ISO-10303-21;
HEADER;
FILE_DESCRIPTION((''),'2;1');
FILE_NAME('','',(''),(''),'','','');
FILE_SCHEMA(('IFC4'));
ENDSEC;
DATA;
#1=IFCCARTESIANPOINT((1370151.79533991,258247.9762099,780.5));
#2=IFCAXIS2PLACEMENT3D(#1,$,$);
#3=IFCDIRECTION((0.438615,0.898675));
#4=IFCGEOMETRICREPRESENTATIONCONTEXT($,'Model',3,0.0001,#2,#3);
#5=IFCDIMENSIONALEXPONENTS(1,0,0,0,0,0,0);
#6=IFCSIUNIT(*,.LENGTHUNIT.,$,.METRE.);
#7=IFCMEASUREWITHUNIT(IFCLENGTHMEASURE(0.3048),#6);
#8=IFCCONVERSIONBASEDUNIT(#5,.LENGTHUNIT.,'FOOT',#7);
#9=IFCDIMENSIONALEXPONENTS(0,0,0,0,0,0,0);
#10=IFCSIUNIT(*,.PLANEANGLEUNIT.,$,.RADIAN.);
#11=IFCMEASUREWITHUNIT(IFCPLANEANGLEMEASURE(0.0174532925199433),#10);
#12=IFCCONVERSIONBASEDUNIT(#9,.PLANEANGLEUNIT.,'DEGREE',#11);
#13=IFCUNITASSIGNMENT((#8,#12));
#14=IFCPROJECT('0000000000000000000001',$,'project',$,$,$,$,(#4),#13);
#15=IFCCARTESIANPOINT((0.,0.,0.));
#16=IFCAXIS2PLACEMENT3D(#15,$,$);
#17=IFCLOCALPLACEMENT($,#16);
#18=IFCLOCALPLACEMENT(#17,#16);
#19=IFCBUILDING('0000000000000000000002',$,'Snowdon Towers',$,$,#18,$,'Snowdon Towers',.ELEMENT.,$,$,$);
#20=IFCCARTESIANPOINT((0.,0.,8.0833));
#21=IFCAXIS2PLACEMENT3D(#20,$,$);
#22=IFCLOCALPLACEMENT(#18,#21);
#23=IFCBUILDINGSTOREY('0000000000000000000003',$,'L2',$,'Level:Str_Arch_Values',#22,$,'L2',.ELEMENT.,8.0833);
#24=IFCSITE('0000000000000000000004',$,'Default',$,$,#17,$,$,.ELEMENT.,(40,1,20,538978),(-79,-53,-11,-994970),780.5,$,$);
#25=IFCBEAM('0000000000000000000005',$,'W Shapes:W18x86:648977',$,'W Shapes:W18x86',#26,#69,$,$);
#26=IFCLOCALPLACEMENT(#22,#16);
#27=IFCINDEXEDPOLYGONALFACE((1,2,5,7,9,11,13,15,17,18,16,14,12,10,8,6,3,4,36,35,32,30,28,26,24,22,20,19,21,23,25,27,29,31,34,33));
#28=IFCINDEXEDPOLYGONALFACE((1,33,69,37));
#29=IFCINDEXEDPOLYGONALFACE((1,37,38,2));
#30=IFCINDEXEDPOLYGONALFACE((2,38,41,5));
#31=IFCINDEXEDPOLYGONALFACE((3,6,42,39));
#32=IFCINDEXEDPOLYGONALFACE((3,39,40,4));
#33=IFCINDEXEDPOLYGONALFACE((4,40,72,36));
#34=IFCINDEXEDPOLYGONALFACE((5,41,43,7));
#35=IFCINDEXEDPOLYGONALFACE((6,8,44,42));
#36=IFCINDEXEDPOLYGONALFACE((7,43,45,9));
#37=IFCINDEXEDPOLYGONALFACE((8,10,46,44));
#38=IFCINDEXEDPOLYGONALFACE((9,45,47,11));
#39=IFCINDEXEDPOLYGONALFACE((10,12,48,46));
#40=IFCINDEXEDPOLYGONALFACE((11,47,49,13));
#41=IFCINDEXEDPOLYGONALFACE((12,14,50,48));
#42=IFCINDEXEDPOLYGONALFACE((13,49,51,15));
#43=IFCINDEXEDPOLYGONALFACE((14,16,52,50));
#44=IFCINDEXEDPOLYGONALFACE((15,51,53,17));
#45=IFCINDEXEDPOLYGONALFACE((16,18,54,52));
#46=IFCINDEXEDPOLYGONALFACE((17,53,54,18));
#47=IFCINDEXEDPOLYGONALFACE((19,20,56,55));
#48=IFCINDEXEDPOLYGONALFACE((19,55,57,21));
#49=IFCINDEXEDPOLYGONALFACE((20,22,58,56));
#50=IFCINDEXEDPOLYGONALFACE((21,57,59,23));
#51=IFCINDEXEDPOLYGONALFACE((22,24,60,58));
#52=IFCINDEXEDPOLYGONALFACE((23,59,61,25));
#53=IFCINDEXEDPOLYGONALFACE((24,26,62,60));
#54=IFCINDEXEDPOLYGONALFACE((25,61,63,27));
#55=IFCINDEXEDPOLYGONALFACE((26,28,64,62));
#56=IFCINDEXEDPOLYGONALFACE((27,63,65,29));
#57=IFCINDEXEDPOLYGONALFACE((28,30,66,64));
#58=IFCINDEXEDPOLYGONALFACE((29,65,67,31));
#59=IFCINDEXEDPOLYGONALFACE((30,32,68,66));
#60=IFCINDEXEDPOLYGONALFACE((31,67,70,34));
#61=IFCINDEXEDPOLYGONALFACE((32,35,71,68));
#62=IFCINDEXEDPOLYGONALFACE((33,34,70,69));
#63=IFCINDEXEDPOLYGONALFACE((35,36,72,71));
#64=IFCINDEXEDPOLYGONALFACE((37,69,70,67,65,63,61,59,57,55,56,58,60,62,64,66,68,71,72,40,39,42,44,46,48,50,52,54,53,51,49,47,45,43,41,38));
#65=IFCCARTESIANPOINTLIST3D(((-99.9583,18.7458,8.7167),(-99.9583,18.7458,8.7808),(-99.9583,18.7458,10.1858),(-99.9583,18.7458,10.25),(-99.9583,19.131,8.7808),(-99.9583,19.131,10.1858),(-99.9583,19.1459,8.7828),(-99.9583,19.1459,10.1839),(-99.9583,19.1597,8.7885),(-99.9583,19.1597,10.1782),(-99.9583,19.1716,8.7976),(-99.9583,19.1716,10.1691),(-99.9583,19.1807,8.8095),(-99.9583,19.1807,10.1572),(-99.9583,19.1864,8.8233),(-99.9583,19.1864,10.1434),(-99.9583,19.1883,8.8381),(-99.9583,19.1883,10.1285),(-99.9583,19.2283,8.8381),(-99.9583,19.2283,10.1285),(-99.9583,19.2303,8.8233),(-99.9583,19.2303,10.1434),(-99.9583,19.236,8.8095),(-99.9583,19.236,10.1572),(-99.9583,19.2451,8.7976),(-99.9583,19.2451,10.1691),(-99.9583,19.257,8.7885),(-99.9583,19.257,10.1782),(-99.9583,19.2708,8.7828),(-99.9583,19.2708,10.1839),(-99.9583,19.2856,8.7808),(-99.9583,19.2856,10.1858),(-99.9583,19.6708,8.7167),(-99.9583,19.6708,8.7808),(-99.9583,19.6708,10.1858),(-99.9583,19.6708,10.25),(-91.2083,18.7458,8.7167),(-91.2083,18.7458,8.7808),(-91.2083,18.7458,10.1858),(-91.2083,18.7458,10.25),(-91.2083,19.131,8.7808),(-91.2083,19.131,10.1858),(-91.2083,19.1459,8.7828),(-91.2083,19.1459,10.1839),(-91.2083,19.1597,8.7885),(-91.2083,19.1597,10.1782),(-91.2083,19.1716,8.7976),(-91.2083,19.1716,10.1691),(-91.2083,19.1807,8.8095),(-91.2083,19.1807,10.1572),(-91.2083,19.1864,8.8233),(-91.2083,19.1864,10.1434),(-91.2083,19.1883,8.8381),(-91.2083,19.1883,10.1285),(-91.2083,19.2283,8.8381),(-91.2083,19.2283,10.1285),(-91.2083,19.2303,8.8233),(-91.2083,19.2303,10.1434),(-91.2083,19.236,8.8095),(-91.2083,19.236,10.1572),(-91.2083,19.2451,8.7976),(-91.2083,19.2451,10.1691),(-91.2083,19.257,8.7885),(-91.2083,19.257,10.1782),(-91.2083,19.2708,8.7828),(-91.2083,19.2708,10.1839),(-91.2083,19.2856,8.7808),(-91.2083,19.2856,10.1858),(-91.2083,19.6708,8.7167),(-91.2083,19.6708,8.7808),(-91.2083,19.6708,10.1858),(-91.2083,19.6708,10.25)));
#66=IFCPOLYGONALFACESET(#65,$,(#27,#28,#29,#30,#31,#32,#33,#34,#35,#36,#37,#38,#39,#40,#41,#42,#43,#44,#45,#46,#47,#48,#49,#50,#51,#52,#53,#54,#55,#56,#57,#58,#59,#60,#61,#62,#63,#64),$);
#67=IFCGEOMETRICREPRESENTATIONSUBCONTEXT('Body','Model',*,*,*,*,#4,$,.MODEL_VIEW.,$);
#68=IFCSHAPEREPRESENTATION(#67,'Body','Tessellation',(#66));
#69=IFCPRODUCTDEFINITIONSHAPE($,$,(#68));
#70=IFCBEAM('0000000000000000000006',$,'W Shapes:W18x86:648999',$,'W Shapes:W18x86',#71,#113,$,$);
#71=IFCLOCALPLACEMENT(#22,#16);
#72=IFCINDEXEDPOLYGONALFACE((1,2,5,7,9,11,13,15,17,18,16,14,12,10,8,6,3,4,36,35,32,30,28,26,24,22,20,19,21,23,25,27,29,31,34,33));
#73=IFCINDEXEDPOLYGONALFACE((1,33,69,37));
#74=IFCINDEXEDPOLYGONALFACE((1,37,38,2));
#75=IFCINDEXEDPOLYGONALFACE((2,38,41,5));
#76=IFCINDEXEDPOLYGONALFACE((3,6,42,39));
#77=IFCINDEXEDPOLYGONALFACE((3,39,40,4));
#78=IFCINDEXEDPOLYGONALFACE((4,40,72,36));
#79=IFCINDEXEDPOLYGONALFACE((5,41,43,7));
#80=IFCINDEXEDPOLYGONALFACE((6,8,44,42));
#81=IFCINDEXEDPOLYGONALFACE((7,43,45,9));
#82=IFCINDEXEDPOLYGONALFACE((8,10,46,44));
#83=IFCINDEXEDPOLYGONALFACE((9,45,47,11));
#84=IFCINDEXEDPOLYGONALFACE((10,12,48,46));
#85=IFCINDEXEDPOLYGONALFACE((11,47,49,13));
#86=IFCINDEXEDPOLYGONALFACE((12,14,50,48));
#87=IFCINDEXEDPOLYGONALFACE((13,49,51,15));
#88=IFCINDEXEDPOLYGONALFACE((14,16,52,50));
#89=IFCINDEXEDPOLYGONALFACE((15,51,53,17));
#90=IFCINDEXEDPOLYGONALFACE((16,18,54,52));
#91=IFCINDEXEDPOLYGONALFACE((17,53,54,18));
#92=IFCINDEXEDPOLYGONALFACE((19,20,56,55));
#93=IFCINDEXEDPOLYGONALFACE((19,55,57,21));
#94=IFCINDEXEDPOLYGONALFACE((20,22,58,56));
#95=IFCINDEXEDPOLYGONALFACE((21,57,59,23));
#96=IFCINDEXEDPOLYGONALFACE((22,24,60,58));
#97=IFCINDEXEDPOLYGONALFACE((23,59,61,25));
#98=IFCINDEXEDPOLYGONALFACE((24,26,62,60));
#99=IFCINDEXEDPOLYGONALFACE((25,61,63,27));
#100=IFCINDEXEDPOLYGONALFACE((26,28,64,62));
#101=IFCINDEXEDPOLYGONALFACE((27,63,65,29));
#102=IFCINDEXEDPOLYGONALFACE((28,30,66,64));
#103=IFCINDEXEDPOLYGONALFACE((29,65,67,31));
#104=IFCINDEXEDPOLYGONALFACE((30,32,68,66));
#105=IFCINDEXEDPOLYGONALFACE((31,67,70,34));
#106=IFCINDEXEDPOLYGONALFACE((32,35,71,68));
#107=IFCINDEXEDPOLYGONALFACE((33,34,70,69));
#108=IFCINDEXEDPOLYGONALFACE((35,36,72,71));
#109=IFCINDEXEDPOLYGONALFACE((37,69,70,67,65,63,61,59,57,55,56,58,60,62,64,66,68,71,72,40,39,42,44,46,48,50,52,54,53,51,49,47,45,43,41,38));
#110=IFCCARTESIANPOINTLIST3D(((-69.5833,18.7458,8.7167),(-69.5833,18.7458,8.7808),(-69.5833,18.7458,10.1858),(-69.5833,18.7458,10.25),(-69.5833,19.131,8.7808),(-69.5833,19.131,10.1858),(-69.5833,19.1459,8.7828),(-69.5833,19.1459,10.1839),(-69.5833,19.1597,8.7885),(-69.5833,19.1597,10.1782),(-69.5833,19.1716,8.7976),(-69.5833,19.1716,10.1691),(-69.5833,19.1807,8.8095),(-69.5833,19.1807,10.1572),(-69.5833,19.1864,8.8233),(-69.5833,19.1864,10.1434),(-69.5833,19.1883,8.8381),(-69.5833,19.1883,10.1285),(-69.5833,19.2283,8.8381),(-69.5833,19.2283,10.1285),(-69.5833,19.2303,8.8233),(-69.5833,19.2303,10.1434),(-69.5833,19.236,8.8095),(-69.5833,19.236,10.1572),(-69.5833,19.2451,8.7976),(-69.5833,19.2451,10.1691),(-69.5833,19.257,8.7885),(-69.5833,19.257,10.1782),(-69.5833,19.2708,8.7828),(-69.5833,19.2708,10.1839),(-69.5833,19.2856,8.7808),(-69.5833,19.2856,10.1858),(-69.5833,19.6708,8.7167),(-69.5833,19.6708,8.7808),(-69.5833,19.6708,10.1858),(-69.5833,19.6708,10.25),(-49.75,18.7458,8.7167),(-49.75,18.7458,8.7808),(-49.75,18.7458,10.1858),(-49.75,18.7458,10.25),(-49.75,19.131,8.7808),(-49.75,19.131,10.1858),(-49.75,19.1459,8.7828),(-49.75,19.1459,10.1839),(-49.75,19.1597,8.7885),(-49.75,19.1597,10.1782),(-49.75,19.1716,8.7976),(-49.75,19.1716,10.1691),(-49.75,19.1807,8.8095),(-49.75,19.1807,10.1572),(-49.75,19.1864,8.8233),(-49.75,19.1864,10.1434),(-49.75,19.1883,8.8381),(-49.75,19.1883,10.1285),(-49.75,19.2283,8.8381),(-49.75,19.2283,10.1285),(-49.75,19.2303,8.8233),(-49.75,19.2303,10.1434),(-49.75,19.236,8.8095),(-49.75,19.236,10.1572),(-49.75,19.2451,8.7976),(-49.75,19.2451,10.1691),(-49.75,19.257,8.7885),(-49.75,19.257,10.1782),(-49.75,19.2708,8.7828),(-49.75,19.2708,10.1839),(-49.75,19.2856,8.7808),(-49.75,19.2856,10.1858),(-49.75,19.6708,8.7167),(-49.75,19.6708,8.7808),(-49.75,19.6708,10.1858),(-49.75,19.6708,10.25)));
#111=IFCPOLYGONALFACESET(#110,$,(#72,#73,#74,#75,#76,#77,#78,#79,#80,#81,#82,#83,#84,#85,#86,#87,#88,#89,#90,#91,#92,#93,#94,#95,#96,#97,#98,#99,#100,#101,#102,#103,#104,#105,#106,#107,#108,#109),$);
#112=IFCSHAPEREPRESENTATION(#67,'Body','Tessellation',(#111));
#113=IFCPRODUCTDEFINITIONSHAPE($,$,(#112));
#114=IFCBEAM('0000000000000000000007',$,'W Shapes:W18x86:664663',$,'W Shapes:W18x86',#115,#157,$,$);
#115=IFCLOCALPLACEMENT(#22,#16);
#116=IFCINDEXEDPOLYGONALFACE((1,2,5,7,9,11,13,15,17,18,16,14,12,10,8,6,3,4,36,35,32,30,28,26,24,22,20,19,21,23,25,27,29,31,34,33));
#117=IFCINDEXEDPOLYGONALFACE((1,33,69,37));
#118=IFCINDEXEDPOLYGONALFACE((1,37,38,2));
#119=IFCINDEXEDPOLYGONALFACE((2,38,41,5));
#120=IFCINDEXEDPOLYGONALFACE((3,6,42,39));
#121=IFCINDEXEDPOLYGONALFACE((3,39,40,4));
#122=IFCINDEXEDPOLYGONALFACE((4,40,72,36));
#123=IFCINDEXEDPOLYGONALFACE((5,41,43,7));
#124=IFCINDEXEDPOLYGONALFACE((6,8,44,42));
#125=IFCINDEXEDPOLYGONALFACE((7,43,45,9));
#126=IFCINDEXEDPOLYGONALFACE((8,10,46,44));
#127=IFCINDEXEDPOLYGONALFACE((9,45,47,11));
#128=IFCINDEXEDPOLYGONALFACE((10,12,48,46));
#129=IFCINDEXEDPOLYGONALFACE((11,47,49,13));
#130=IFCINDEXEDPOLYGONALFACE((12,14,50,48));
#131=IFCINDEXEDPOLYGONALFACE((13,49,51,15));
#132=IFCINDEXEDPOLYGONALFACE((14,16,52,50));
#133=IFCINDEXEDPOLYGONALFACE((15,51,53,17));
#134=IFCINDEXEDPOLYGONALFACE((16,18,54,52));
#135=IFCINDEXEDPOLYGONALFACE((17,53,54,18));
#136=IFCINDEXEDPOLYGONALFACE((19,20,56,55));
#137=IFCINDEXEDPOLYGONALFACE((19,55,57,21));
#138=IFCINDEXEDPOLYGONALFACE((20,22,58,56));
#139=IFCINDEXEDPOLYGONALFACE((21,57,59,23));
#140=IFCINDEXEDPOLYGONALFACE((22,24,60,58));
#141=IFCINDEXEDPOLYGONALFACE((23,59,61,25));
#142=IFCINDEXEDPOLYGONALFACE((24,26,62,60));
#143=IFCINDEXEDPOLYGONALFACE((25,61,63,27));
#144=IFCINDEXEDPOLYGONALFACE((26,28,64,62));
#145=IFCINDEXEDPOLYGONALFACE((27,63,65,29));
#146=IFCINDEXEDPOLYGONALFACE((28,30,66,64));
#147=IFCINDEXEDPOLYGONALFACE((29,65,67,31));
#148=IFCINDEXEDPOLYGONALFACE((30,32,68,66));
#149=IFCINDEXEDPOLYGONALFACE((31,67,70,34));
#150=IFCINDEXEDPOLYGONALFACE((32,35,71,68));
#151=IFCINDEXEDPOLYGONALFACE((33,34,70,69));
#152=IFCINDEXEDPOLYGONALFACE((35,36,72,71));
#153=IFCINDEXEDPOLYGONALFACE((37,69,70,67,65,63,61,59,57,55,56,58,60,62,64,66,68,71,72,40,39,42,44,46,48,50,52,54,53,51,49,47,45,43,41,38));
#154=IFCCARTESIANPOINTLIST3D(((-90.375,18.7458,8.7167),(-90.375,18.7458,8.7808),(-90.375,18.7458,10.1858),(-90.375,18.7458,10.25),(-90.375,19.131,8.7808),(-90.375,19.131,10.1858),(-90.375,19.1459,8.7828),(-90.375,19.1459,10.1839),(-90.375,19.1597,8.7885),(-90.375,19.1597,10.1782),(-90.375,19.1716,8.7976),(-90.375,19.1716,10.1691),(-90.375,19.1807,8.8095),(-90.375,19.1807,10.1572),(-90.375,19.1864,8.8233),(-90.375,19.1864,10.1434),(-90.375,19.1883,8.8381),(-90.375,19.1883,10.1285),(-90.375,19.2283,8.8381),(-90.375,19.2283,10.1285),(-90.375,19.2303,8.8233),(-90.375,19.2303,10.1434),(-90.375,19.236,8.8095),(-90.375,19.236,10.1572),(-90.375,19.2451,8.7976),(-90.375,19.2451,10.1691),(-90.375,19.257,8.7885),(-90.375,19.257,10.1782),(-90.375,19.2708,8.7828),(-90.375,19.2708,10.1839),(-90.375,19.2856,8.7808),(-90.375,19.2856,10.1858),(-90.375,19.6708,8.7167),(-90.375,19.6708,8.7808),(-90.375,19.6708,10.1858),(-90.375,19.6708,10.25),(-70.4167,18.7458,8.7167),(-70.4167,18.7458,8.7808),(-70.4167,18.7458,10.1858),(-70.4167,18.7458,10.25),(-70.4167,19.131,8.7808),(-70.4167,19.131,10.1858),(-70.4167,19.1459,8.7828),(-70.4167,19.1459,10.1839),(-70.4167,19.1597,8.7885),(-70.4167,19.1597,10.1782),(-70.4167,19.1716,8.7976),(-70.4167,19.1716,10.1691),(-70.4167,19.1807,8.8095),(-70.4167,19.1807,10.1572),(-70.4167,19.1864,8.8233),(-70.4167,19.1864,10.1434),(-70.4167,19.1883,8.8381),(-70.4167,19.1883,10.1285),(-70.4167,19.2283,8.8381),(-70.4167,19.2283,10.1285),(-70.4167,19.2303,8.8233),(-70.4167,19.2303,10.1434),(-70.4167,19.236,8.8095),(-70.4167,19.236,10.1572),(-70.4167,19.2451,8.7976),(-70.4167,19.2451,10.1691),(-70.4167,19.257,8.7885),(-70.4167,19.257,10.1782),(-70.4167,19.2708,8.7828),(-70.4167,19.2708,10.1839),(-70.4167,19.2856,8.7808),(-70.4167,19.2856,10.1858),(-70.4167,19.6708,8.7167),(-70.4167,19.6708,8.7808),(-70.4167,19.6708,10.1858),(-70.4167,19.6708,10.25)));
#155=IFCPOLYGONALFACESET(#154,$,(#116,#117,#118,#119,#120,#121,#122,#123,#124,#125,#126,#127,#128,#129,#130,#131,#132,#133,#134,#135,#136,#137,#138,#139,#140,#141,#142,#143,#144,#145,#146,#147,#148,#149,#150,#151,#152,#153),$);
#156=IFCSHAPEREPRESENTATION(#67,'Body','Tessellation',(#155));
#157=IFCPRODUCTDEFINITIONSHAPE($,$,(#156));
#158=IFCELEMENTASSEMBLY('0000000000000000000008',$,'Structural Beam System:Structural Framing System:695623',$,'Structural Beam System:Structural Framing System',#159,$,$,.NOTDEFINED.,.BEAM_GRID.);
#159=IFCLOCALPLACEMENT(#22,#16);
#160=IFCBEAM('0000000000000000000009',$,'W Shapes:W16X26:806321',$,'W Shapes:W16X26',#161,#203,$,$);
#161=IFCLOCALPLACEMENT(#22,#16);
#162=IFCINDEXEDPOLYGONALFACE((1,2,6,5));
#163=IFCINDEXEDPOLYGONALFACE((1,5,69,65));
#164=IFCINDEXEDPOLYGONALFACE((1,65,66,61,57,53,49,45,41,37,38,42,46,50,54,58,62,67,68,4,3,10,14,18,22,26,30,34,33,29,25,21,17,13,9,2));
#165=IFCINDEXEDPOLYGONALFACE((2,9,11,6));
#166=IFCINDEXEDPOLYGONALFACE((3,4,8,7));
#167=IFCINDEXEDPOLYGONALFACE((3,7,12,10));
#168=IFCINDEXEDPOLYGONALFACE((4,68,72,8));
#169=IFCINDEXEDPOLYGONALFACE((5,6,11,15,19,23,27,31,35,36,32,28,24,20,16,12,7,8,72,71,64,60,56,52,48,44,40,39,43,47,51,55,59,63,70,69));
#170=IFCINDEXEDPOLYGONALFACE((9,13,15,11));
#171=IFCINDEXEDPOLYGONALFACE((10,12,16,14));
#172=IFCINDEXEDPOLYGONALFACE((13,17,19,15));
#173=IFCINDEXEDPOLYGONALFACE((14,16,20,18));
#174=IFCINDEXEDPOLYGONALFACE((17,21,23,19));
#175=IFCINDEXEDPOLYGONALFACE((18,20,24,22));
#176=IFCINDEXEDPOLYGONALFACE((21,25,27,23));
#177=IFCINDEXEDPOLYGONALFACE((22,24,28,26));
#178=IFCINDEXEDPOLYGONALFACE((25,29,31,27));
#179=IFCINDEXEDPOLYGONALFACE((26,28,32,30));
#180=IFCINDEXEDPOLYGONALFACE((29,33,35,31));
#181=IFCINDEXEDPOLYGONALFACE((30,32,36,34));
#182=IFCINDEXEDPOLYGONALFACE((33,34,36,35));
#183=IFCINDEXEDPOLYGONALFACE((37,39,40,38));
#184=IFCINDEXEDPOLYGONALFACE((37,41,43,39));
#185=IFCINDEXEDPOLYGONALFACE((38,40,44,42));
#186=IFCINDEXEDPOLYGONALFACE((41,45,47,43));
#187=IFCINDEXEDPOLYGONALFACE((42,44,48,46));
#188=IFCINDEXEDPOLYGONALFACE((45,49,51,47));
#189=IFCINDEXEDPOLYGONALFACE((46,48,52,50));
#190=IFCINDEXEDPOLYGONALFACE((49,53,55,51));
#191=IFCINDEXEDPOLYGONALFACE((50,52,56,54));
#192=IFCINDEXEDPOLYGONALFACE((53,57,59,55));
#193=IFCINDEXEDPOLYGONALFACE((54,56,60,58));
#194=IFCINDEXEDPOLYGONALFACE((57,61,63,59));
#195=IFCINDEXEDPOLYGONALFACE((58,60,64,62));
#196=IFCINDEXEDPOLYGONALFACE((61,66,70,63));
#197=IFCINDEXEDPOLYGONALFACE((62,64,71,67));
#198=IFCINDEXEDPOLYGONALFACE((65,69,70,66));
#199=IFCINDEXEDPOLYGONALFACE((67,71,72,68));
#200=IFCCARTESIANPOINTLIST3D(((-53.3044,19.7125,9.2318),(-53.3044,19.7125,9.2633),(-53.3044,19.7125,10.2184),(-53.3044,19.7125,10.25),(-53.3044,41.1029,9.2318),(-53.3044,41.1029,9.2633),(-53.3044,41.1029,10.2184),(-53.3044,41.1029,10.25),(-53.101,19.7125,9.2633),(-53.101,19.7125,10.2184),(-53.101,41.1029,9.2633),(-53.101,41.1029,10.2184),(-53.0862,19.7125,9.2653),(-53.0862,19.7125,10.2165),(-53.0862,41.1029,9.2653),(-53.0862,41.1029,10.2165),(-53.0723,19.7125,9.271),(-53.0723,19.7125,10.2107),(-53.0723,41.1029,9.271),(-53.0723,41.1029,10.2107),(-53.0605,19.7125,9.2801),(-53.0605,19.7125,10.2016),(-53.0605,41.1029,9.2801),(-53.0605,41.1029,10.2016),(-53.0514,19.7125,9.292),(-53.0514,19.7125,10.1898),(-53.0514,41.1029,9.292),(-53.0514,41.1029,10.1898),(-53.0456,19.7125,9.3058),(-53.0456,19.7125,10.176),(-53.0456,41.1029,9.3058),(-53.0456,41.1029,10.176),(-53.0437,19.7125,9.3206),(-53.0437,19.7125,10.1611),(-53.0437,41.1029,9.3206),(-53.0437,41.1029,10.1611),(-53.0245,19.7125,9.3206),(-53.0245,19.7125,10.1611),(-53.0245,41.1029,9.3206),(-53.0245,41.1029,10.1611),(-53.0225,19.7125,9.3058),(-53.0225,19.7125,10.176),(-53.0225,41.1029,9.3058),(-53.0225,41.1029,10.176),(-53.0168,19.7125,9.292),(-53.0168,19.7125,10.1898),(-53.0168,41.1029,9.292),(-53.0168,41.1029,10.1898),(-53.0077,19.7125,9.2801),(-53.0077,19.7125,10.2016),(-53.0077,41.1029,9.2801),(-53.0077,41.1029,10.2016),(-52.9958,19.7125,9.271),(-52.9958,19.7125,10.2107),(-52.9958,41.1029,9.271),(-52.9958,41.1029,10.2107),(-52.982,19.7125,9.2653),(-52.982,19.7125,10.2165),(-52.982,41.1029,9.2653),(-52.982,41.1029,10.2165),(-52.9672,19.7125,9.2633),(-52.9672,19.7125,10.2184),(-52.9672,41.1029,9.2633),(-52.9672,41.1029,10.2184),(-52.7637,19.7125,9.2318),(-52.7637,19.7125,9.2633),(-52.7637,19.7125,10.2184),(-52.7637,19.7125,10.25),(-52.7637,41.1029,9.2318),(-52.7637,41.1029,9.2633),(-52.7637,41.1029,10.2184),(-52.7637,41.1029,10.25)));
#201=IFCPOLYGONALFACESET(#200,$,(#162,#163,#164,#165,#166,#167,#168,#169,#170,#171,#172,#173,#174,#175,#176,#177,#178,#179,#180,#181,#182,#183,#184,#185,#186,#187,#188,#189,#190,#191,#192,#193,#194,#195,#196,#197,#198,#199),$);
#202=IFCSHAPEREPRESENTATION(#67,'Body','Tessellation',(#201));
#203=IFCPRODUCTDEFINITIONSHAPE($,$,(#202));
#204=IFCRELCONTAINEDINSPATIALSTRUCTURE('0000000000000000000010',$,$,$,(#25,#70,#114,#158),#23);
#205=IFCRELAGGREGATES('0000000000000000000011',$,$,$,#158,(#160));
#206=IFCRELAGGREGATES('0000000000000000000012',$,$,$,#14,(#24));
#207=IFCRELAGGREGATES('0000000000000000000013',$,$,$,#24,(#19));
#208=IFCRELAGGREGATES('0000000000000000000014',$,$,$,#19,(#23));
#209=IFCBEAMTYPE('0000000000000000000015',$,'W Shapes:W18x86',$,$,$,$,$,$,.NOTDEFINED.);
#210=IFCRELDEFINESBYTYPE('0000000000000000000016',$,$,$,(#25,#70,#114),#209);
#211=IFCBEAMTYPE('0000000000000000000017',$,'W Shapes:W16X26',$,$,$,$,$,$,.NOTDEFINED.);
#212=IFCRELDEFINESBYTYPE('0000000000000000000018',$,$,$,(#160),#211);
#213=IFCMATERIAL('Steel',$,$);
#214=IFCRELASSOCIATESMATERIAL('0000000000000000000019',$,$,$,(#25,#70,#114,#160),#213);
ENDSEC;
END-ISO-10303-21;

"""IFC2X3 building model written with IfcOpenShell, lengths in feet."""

from ifc_helpers import new_model, entity, si_unit, converted_unit, direction, frame, frame_2d, origin, place, context, subcontext, project, spatial, i_section, extrude, material, type_object, element, aggregate, save


model = new_model("IFC2X3")

# Units and contexts
model_context = context("Model", 3, precision=0.0001, world=frame((1370151.79533991, 258247.9762099, 780.5)), true_north=direction((0.438615, 0.898675)))
body_context = subcontext(model_context, "Body", "Model", "MODEL_VIEW")
ifc_project = project(units=[converted_unit("LENGTHUNIT", "FOOT", entity("IfcLengthMeasure", 0.3048), si_unit("LENGTHUNIT", "METRE"), dimensions=[1, 0, 0, 0, 0, 0, 0]), converted_unit("PLANEANGLEUNIT", "DEGREE", entity("IfcPlaneAngleMeasure", 0.0174532925199433), si_unit("PLANEANGLEUNIT", "RADIAN"), dimensions=[0, 0, 0, 0, 0, 0, 0])], contexts=[model_context])

# Site, building, storey
site_placement = place(None, origin())
site = spatial("IfcSite", under=ifc_project, at=site_placement, Name="Default", CompositionType="ELEMENT", RefLatitude=(40, 1, 20, 538978), RefLongitude=(-79, -53, -11, -994970), RefElevation=780.5)
building_placement = place(site_placement, origin())
building = spatial("IfcBuilding", under=site, at=building_placement, Name="Snowdon Towers", LongName="Snowdon Towers", CompositionType="ELEMENT")
storey_placement = place(building_placement, frame((0.0, 0.0, 8.0833)))
storey = spatial("IfcBuildingStorey", under=building, at=storey_placement, Name="L2", ObjectType="Level:Str_Arch_Values", LongName="L2", CompositionType="ELEMENT", Elevation=8.0833)

# Shared definitions
ifc_material = material(Name="Steel")

# Beams
beam_type_1 = type_object("IfcBeamType", Name="W Shapes:W18x86", PredefinedType="NOTDEFINED")
beam_1_placement = place(storey_placement, frame((-99.9583, 19.2083, 10.25)))
element("IfcBeam", 1, at=beam_1_placement, inside=storey, type_object=beam_type_1, material=ifc_material, Name="W Shapes:W18x86:648977", ObjectType="W Shapes:W18x86", context=body_context, shape_type="SweptSolid", body=[
    extrude(i_section(OverallWidth=0.925, OverallDepth=1.5333, WebThickness=0.04, FlangeThickness=0.0642, FilletRadius=0.0573, at=frame_2d((0.0, 0.0), x_axis=(0.0, 1.0))), frame((0.0, 0.0, -0.7667), z_axis=(1.0, 0.0, 0.0), x_axis=(0.0, 0.0, -1.0)), (0.0, 0.0, 1.0), 8.75),
])
beam_2_placement = place(storey_placement, frame((-70.0, 19.2083, 10.25)))
element("IfcBeam", 2, at=beam_2_placement, inside=storey, type_object=beam_type_1, material=ifc_material, Name="W Shapes:W18x86:648999", ObjectType="W Shapes:W18x86", context=body_context, shape_type="SweptSolid", body=[
    extrude(i_section(OverallWidth=0.925, OverallDepth=1.5333, WebThickness=0.04, FlangeThickness=0.0642, FilletRadius=0.0573, at=frame_2d((0.0, 0.0), x_axis=(0.0, 1.0))), frame((0.4167, 0.0, -0.7667), z_axis=(1.0, 0.0, 0.0), x_axis=(0.0, 0.0, -1.0)), (0.0, 0.0, 1.0), 19.8333),
])
beam_3_placement = place(storey_placement, frame((-90.75, 19.2083, 10.25)))
element("IfcBeam", 3, at=beam_3_placement, inside=storey, type_object=beam_type_1, material=ifc_material, Name="W Shapes:W18x86:664663", ObjectType="W Shapes:W18x86", context=body_context, shape_type="SweptSolid", body=[
    extrude(i_section(OverallWidth=0.925, OverallDepth=1.5333, WebThickness=0.04, FlangeThickness=0.0642, FilletRadius=0.0573, at=frame_2d((0.0, 0.0), x_axis=(0.0, 1.0))), frame((0.375, 0.0, -0.7667), z_axis=(1.0, 0.0, 0.0), x_axis=(0.0, 0.0, -1.0)), (0.0, 0.0, 1.0), 19.9583),
])

# Element assembly, beam
assembly_1_placement = place(storey_placement, origin())
assembly_1 = element("IfcElementAssembly", 4, at=assembly_1_placement, inside=storey, Name="Structural Beam System:Structural Framing System:695623", ObjectType="Structural Beam System:Structural Framing System", AssemblyPlace="NOTDEFINED", PredefinedType="BEAM_GRID")
beam_type_2 = type_object("IfcBeamType", Name="W Shapes:W16X26", PredefinedType="NOTDEFINED")
beam_4_placement = place(assembly_1_placement, frame((-53.0341, 41.4583, 10.25), z_axis=(0.0, 0.0, 1.0), x_axis=(0.0, -1.0, 0.0)))
beam_4 = element("IfcBeam", 5, at=beam_4_placement, type_object=beam_type_2, material=ifc_material, Name="W Shapes:W16X26:806321", ObjectType="W Shapes:W16X26", context=body_context, shape_type="SweptSolid", body=[
    extrude(i_section(OverallWidth=0.5407, OverallDepth=1.0182, WebThickness=0.0192, FlangeThickness=0.0316, FilletRadius=0.0573, at=frame_2d((0.0, 0.0), x_axis=(0.0, 1.0))), frame((0.3554, 0.0, -0.5091), z_axis=(1.0, 0.0, 0.0), x_axis=(0.0, 0.0, -1.0)), (0.0, 0.0, 1.0), 21.3904),
])
aggregate(assembly_1, [beam_4])

save(model, "model.ifc")
